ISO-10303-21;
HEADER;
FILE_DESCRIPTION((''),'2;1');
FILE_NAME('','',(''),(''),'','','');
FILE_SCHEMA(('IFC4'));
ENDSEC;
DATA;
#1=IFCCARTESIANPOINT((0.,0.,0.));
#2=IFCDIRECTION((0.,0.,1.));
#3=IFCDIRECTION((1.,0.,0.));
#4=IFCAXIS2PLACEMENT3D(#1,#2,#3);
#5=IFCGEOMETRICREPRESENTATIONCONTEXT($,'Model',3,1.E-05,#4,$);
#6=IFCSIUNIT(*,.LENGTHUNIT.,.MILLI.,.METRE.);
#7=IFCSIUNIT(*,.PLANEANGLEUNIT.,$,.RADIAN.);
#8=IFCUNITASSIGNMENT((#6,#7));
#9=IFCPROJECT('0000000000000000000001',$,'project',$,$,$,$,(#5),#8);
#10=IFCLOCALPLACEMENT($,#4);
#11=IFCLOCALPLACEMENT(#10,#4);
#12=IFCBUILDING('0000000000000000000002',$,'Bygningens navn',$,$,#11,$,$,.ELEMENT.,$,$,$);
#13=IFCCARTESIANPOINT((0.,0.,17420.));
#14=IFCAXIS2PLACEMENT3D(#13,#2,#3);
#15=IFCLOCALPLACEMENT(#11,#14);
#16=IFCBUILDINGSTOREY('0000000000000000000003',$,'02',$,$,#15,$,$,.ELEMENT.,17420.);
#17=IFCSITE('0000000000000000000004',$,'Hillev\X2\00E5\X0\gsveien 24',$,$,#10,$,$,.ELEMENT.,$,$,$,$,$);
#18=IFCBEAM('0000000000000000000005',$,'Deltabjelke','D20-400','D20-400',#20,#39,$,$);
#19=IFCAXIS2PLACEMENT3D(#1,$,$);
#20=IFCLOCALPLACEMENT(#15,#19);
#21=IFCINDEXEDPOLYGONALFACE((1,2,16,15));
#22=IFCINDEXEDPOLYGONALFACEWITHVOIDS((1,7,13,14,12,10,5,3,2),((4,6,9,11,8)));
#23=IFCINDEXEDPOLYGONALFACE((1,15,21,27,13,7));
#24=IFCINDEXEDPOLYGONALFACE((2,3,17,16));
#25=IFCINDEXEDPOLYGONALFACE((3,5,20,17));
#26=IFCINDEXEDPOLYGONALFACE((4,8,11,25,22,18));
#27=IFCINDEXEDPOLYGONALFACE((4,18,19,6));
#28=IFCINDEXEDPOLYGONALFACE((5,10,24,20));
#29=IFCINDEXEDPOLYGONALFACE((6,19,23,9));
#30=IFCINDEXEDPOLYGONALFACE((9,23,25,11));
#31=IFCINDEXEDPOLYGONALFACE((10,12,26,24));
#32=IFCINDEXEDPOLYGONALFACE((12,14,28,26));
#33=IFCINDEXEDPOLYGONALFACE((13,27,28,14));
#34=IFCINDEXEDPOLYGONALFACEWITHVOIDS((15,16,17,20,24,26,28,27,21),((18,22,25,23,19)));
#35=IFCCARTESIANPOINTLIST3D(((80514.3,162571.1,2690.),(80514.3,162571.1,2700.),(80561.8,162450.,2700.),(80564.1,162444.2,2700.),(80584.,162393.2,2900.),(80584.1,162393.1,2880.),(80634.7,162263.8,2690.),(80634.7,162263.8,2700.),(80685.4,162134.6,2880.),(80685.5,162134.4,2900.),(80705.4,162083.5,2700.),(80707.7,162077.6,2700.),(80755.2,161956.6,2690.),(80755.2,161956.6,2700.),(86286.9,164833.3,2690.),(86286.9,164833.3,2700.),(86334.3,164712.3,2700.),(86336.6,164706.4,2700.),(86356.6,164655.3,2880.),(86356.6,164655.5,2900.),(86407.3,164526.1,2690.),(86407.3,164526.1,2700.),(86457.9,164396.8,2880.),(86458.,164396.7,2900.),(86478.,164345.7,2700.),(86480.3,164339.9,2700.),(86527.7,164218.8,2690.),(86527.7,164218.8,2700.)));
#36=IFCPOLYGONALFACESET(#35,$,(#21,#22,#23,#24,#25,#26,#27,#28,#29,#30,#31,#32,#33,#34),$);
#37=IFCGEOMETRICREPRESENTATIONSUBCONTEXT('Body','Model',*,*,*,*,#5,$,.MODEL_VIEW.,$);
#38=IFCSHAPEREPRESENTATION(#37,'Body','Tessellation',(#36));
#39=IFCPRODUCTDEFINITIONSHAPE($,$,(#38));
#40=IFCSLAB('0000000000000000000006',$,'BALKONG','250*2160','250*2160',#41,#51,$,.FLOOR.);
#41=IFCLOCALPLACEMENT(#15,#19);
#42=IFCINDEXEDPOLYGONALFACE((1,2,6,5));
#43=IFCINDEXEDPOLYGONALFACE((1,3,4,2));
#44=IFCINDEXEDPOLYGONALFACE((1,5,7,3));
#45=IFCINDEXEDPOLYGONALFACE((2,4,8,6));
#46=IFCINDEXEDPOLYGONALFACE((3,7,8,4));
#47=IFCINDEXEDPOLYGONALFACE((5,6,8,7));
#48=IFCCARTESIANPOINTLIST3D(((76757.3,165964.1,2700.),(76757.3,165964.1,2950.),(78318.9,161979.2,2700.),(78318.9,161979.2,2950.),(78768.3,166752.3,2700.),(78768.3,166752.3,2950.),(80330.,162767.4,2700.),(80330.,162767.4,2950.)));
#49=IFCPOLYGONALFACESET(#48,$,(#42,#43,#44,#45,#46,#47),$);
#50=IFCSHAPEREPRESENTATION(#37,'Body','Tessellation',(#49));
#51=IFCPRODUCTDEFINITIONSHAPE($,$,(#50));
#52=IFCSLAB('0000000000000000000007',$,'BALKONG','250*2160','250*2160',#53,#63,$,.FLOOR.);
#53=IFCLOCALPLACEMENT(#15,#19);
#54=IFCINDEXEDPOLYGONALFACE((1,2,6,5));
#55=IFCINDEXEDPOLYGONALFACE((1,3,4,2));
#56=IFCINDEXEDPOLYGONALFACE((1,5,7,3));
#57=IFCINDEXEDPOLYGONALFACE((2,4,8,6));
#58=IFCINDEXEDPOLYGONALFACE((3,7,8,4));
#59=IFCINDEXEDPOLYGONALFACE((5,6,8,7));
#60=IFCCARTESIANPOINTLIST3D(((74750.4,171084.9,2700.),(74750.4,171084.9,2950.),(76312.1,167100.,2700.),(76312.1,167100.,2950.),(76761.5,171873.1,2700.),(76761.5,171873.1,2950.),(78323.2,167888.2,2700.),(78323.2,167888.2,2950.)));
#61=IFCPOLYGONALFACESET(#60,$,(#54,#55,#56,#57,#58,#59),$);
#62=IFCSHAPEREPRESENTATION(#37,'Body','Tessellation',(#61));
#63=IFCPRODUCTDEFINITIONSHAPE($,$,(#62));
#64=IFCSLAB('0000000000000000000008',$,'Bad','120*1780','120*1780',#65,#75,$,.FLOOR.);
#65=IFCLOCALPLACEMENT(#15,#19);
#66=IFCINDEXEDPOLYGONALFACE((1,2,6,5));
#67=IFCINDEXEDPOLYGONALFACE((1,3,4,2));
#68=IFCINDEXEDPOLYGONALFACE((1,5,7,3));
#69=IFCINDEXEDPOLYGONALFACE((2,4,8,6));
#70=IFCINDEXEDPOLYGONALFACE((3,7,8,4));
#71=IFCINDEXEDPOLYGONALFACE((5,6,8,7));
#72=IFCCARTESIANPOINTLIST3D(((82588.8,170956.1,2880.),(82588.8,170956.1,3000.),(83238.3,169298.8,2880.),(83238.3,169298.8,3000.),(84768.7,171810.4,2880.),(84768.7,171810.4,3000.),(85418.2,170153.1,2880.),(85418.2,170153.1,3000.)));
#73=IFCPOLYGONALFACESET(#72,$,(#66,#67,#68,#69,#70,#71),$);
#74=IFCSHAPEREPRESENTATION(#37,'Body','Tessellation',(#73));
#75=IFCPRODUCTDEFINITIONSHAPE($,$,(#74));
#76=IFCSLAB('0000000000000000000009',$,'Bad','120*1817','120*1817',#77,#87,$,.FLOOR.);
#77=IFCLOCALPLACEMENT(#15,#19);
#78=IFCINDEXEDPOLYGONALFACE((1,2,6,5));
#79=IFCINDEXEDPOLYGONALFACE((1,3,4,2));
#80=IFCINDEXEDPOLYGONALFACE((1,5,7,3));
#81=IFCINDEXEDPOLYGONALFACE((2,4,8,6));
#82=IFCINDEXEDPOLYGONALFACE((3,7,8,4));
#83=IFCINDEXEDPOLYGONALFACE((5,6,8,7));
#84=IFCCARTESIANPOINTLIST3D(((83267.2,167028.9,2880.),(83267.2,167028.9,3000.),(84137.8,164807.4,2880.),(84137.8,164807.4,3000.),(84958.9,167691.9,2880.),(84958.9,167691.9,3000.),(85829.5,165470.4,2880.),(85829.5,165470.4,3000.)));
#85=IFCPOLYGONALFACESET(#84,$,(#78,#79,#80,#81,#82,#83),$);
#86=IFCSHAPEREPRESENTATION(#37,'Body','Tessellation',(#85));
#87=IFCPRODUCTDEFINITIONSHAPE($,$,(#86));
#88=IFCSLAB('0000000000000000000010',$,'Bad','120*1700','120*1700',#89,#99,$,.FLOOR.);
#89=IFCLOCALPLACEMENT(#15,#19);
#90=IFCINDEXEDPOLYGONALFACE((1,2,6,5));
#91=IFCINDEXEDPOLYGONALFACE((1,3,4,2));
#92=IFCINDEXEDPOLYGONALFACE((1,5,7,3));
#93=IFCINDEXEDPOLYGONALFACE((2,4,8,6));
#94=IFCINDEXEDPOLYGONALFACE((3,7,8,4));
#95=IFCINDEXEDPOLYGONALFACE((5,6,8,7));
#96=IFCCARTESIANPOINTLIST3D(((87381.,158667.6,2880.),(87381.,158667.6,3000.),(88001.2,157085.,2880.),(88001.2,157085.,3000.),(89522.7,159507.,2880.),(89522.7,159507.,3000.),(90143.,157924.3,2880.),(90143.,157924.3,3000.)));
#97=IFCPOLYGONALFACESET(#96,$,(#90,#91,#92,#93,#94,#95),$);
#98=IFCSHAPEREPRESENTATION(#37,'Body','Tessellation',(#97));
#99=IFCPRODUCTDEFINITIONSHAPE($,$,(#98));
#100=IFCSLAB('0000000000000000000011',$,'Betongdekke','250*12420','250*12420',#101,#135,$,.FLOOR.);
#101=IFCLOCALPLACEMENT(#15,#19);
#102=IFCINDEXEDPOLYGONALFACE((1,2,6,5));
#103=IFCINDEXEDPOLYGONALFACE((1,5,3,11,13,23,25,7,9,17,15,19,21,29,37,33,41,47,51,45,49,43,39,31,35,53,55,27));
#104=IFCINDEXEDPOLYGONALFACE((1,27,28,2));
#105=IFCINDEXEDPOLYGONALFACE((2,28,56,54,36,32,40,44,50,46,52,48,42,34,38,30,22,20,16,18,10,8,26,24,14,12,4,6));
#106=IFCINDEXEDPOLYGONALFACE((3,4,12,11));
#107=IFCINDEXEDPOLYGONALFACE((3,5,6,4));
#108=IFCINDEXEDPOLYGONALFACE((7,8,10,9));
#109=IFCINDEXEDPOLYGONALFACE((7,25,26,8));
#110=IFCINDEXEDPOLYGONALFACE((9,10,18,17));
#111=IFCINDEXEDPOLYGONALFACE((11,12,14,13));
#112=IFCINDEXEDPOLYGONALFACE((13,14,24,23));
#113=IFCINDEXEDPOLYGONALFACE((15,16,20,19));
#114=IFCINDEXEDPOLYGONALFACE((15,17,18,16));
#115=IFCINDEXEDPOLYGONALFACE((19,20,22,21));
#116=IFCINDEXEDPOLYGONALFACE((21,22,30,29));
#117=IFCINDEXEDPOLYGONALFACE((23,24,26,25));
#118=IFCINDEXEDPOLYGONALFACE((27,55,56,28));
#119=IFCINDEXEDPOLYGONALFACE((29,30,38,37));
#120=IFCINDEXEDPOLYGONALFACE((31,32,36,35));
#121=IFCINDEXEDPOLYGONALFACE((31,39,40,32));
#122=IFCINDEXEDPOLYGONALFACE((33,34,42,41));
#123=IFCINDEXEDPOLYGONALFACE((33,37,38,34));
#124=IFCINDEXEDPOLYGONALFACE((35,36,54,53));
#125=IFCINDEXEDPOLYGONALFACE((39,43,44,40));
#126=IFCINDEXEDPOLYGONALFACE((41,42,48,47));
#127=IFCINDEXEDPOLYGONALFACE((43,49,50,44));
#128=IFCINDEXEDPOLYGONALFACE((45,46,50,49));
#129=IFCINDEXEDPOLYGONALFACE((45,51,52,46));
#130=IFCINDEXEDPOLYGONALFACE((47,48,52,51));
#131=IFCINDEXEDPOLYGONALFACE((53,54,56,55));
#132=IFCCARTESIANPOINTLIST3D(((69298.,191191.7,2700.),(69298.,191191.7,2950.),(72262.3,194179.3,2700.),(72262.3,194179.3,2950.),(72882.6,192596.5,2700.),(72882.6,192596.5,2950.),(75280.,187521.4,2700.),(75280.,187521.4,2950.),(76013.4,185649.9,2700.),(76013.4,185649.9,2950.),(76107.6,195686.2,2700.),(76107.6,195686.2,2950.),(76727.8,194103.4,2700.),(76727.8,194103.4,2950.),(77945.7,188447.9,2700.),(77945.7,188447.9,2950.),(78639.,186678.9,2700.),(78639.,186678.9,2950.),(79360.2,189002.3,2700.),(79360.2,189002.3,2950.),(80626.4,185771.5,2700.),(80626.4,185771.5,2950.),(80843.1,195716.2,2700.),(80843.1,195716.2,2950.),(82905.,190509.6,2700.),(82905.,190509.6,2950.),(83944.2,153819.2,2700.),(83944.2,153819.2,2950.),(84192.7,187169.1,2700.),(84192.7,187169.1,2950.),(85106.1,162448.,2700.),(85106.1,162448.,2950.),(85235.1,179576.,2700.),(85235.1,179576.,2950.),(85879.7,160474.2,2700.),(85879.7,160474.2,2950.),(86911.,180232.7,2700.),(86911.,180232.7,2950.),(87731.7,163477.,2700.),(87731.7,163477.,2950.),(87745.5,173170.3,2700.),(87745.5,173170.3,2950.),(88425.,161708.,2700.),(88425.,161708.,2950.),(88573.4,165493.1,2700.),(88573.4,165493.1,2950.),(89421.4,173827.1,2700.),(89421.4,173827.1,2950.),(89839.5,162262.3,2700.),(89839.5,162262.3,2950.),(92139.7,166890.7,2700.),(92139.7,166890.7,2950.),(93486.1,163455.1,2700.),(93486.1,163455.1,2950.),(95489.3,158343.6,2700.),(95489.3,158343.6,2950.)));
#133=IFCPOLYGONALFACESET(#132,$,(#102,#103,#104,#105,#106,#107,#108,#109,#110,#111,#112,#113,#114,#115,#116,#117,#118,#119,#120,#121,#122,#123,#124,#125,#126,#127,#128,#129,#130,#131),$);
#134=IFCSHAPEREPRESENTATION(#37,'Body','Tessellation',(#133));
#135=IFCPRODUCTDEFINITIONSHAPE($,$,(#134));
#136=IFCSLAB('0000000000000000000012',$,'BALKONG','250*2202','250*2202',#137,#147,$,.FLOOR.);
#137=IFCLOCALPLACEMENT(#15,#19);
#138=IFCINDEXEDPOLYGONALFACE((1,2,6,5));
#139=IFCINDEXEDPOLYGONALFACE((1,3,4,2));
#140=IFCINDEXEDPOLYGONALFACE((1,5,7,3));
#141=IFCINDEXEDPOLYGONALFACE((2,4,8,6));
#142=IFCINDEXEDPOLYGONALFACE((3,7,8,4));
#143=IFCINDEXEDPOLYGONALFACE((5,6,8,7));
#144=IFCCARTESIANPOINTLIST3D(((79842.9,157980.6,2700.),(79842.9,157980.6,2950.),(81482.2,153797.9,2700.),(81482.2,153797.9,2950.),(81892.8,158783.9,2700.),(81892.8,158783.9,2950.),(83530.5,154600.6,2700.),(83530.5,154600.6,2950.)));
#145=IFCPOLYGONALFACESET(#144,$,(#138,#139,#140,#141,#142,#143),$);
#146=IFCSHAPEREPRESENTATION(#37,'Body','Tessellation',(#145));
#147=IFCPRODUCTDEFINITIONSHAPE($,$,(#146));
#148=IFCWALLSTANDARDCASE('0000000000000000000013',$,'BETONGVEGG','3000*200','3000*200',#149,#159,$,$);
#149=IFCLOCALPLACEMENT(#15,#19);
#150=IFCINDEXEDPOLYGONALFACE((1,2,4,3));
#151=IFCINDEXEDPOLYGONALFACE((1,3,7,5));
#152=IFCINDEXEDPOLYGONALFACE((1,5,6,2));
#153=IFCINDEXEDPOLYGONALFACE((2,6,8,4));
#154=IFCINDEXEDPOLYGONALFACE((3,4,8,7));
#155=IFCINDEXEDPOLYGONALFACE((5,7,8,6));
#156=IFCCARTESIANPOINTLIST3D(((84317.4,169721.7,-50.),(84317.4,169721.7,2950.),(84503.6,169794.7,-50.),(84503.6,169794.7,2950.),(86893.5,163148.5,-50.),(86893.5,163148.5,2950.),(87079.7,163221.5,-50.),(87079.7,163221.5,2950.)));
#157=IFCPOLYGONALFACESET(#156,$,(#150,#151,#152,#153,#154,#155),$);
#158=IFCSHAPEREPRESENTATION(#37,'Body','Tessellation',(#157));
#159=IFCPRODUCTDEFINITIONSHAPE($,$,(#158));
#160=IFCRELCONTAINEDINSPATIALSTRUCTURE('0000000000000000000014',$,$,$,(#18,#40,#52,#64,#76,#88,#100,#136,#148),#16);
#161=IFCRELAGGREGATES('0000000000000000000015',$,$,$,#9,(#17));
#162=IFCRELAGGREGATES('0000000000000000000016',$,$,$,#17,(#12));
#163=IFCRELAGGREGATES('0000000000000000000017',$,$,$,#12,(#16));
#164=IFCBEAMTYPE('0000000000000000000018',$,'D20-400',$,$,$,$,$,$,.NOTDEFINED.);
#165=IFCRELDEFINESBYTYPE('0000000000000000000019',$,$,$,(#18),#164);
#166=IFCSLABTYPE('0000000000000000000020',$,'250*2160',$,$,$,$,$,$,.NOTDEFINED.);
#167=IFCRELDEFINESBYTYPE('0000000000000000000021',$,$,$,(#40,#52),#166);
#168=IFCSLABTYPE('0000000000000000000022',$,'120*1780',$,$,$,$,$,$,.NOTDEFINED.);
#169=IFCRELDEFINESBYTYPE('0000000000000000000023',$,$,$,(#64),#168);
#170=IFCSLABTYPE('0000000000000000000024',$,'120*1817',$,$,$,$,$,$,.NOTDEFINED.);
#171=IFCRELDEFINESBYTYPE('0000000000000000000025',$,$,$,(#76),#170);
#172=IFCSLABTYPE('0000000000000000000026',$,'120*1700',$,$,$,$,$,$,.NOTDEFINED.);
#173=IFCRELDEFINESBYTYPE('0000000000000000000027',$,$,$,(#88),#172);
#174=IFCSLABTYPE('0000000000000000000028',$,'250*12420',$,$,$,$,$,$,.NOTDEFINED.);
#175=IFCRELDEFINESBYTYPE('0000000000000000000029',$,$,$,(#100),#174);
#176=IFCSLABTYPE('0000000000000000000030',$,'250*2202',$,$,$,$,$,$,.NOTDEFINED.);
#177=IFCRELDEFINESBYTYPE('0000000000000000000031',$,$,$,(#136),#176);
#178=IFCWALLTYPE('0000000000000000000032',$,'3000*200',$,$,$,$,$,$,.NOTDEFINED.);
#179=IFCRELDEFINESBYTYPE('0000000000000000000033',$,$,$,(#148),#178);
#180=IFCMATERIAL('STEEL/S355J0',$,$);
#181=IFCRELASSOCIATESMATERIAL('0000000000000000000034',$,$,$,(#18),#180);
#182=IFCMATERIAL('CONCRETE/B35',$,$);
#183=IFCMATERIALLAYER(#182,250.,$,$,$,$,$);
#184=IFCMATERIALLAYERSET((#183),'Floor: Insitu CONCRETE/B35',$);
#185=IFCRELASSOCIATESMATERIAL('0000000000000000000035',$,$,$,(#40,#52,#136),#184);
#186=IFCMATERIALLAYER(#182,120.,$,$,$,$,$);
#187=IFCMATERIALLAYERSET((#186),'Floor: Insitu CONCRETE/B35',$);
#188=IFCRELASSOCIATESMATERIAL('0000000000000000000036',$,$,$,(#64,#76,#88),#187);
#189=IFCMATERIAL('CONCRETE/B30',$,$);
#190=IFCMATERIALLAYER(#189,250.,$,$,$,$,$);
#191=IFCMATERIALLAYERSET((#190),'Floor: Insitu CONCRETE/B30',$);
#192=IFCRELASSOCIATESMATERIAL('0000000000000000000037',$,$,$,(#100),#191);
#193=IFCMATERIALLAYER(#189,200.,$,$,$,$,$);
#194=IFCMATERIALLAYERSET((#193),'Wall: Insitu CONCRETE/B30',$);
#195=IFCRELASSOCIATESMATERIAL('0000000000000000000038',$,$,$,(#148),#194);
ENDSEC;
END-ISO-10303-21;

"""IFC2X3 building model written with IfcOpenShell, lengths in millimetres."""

from ifc_helpers import new_model, si_unit, frame, frame_2d, origin_with_axes, place, context, subcontext, project, spatial, polyline, rectangle, outline, extrude, material, layer, layer_set, layer_usage, type_object, element, save


model = new_model("IFC2X3")

# Units and contexts
model_context = context("Model", 3, precision=1e-05, world=origin_with_axes())
body_context = subcontext(model_context, "Body", "Model", "MODEL_VIEW")
ifc_project = project(units=[si_unit("LENGTHUNIT", "METRE", prefix="MILLI"), si_unit("PLANEANGLEUNIT", "RADIAN")], contexts=[model_context])

# Site, building, storey
site_placement = place(None, origin_with_axes())
site = spatial("IfcSite", under=ifc_project, at=site_placement, Name="Hillevågsveien 24", CompositionType="ELEMENT")
building_placement = place(site_placement, origin_with_axes())
building = spatial("IfcBuilding", under=site, at=building_placement, Name="Bygningens navn", CompositionType="ELEMENT")
storey_placement = place(building_placement, frame((0.0, 0.0, 17420.0), z_axis=(0.0, 0.0, 1.0), x_axis=(1.0, 0.0, 0.0)))
storey = spatial("IfcBuildingStorey", under=building, at=storey_placement, Name="02", CompositionType="ELEMENT", Elevation=17420.0)

# Shared definitions
ifc_material_1 = material(Name="STEEL/S355J0")

# Beam
beam_type_1 = type_object("IfcBeamType", Name="D20-400", PredefinedType="NOTDEFINED")
beam_1_placement = place(storey_placement, frame((86407.3, 164526.1, 2795.0), z_axis=(0.0, 0.0, 1.0), x_axis=(-0.931056, -0.364877, 0.0)))
element("IfcBeam", 1, at=beam_1_placement, inside=storey, type_object=beam_type_1, material=ifc_material_1, Name="Deltabjelke", Description="D20-400", ObjectType="D20-400", context=body_context, shape_type="SweptSolid", body=[
    extrude(outline(polyline([(0.0, -105.0), (-330.0, -105.0), (-330.0, -95.0), (-200.0, -95.0), (-139.0, 105.0), (139.0, 105.0), (200.0, -95.0), (330.0, -95.0), (330.0, -105.0), (0.0, -105.0)]), holes=[polyline([(138.8, 85.0), (-138.8, 85.0), (-193.7, -95.0), (0.0, -95.0), (193.7, -95.0), (138.8, 85.0)])]), frame((6200.0, 0.0, 0.0), z_axis=(-1.0, 0.0, 0.0), x_axis=(0.0, -1.0, 0.0)), (0.0, 0.0, 1.0), 6200.0),
])

# Slabs
ifc_material_2 = material(Name="CONCRETE/B35")
ifc_layer_1 = layer(ifc_material_2, 250.0)
ifc_layer_set_1 = layer_set([ifc_layer_1], Name="Floor: Insitu CONCRETE/B35")
ifc_layer_usage_1 = layer_usage(ifc_layer_set_1, "AXIS3", "POSITIVE", -125.0)
slab_type_1 = type_object("IfcSlabType", Name="250*2160", PredefinedType="NOTDEFINED")
slab_1_placement = place(storey_placement, frame((78318.9, 161979.2, 2825.0), z_axis=(0.0, 0.0, -1.0), x_axis=(-0.364876, 0.931056, 0.0)))
element("IfcSlab", 2, at=slab_1_placement, inside=storey, type_object=slab_type_1, material=ifc_layer_usage_1, Name="BALKONG", Description="250*2160", ObjectType="250*2160", PredefinedType="FLOOR", context=body_context, shape_type="SweptSolid", body=[
    extrude(outline(polyline([(0.0, 0.0), (4280.0, 0.0), (4280.0, 2160.0), (0.0, 2160.0), (0.0, 0.0)])), frame((0.0, 0.0, -125.0), z_axis=(0.0, 0.0, 1.0), x_axis=(1.0, 0.0, 0.0)), (0.0, 0.0, 1.0), 250.0),
])
ifc_layer_usage_2 = layer_usage(ifc_layer_set_1, "AXIS3", "POSITIVE", -125.0)
slab_2_placement = place(storey_placement, frame((76312.1, 167100.0, 2825.0), z_axis=(0.0, 0.0, -1.0), x_axis=(-0.364876, 0.931056, 0.0)))
element("IfcSlab", 3, at=slab_2_placement, inside=storey, type_object=slab_type_1, material=ifc_layer_usage_2, Name="BALKONG", Description="250*2160", ObjectType="250*2160", PredefinedType="FLOOR", context=body_context, shape_type="SweptSolid", body=[
    extrude(outline(polyline([(0.0, 0.0), (4280.0, 0.0), (4280.0, 2160.0), (0.0, 2160.0), (0.0, 0.0)])), frame((0.0, 0.0, -125.0), z_axis=(0.0, 0.0, 1.0), x_axis=(1.0, 0.0, 0.0)), (0.0, 0.0, 1.0), 250.0),
])
ifc_layer_2 = layer(ifc_material_2, 120.0)
ifc_layer_set_2 = layer_set([ifc_layer_2], Name="Floor: Insitu CONCRETE/B35")
ifc_layer_usage_3 = layer_usage(ifc_layer_set_2, "AXIS3", "POSITIVE", -60.0)
slab_type_2 = type_object("IfcSlabType", Name="120*1780", PredefinedType="NOTDEFINED")
slab_3_placement = place(storey_placement, frame((83238.3, 169298.8, 2940.0), z_axis=(0.0, 0.0, -1.0), x_axis=(-0.364877, 0.931056, 0.0)))
element("IfcSlab", 4, at=slab_3_placement, inside=storey, type_object=slab_type_2, material=ifc_layer_usage_3, Name="Bad", Description="120*1780", ObjectType="120*1780", PredefinedType="FLOOR", context=body_context, shape_type="SweptSolid", body=[
    extrude(outline(polyline([(0.0, 0.0), (1780.0, 0.0), (1780.0, 2341.4), (0.0, 2341.4), (0.0, 0.0)])), frame((0.0, 0.0, -60.0), z_axis=(0.0, 0.0, 1.0), x_axis=(1.0, 0.0, 0.0)), (0.0, 0.0, 1.0), 120.0),
])
ifc_layer_usage_4 = layer_usage(ifc_layer_set_2, "AXIS3", "POSITIVE", -60.0)
slab_type_3 = type_object("IfcSlabType", Name="120*1817", PredefinedType="NOTDEFINED")
slab_4_placement = place(storey_placement, frame((84137.8, 164807.4, 2940.0), z_axis=(0.0, 0.0, -1.0), x_axis=(-0.364877, 0.931056, 0.0)))
element("IfcSlab", 5, at=slab_4_placement, inside=storey, type_object=slab_type_3, material=ifc_layer_usage_4, Name="Bad", Description="120*1817", ObjectType="120*1817", PredefinedType="FLOOR", context=body_context, shape_type="SweptSolid", body=[
    extrude(outline(polyline([(0.0, 0.0), (2386.0, 0.0), (2386.0, 1817.0), (0.0, 1817.0), (0.0, 0.0)])), frame((0.0, 0.0, -60.0), z_axis=(0.0, 0.0, 1.0), x_axis=(1.0, 0.0, 0.0)), (0.0, 0.0, 1.0), 120.0),
])
ifc_layer_usage_5 = layer_usage(ifc_layer_set_2, "AXIS3", "POSITIVE", -60.0)
slab_type_4 = type_object("IfcSlabType", Name="120*1700", PredefinedType="NOTDEFINED")
slab_5_placement = place(storey_placement, frame((89522.7, 159507.0, 2940.0), z_axis=(0.0, 0.0, 1.0), x_axis=(-0.931056, -0.364877, 0.0)))
element("IfcSlab", 6, at=slab_5_placement, inside=storey, type_object=slab_type_4, material=ifc_layer_usage_5, Name="Bad", Description="120*1700", ObjectType="120*1700", PredefinedType="FLOOR", context=body_context, shape_type="SweptSolid", body=[
    extrude(outline(polyline([(0.0, 0.0), (2300.4, 0.0), (2300.4, 1699.8), (0.0, 1699.8), (0.0, 0.0)])), frame((0.0, 0.0, -60.0), z_axis=(0.0, 0.0, 1.0), x_axis=(1.0, 0.0, 0.0)), (0.0, 0.0, 1.0), 120.0),
])
ifc_material_3 = material(Name="CONCRETE/B30")
ifc_layer_3 = layer(ifc_material_3, 250.0)
ifc_layer_set_3 = layer_set([ifc_layer_3], Name="Floor: Insitu CONCRETE/B30")
ifc_layer_usage_6 = layer_usage(ifc_layer_set_3, "AXIS3", "POSITIVE", -125.0)
slab_type_5 = type_object("IfcSlabType", Name="250*12420", PredefinedType="NOTDEFINED")
slab_6_placement = place(storey_placement, frame((83944.2, 153819.2, 2825.0), z_axis=(0.0, 0.0, 1.0), x_axis=(0.931056, 0.364877, 0.0)))
element("IfcSlab", 7, at=slab_6_placement, inside=storey, type_object=slab_type_5, material=ifc_layer_usage_6, Name="Betongdekke", Description="250*12420", ObjectType="250*12420", PredefinedType="FLOOR", context=body_context, shape_type="SweptSolid", body=[
    extrude(outline(polyline([(0.0, 0.0), (12400.0, 0.0), (12400.0, 5490.0), (4230.3, 5490.0), (4230.3, 7610.0), (7050.3, 7610.0), (7050.4, 5710.0), (8569.6, 5710.0), (8569.6, 9180.0), (12400.0, 9180.0), (12400.0, 16630.0), (10600.0, 16630.0), (10600.0, 23510.0), (12400.0, 23510.0), (12400.0, 30960.0), (8569.6, 30960.0), (8569.6, 34430.0), (7050.3, 34430.0), (7050.3, 32530.0), (4230.3, 32530.0), (4230.3, 34540.0), (12420.0, 34540.0), (12400.0, 40140.0), (7980.0, 40140.0), (7980.0, 41840.0), (3850.0, 41840.0), (3850.0, 40140.0), (0.0, 40140.0), (0.0, 0.0)])), frame((0.0, 0.0, -125.0), z_axis=(0.0, 0.0, 1.0), x_axis=(1.0, 0.0, 0.0)), (0.0, 0.0, 1.0), 250.0),
])
ifc_layer_usage_7 = layer_usage(ifc_layer_set_1, "AXIS3", "POSITIVE", -125.0)
slab_type_6 = type_object("IfcSlabType", Name="250*2202", PredefinedType="NOTDEFINED")
slab_7_placement = place(storey_placement, frame((79842.9, 157980.6, 2825.0), z_axis=(0.0, 0.0, 1.0), x_axis=(0.364901, -0.931046, 0.0)))
element("IfcSlab", 8, at=slab_7_placement, inside=storey, type_object=slab_type_6, material=ifc_layer_usage_7, Name="BALKONG", Description="250*2202", ObjectType="250*2202", PredefinedType="FLOOR", context=body_context, shape_type="SweptSolid", body=[
    extrude(outline(polyline([(0.0, 0.0), (4492.5, 0.0), (4492.6, 2200.0), (0.1, 2201.7), (0.0, 0.0)])), frame((0.0, 0.0, -125.0), z_axis=(0.0, 0.0, 1.0), x_axis=(1.0, 0.0, 0.0)), (0.0, 0.0, 1.0), 250.0),
])

# Wall
ifc_layer_4 = layer(ifc_material_3, 200.0)
ifc_layer_set_4 = layer_set([ifc_layer_4], Name="Wall: Insitu CONCRETE/B30")
ifc_layer_usage_8 = layer_usage(ifc_layer_set_4, "AXIS2", "POSITIVE", -100.0)
wall_type_1 = type_object("IfcWallType", Name="3000*200", PredefinedType="NOTDEFINED")
wall_1_placement = place(storey_placement, frame((86986.6, 163185.0, -50.0), z_axis=(0.0, 0.0, 1.0), x_axis=(-0.364877, 0.931056, 0.0)))
element("IfcWallStandardCase", 9, at=wall_1_placement, inside=storey, type_object=wall_type_1, material=ifc_layer_usage_8, Name="BETONGVEGG", Description="3000*200", ObjectType="3000*200", context=body_context, shape_type="SweptSolid", body=[
    extrude(rectangle(XDim=7060.0, YDim=200.0, at=frame_2d((0.0, 3530.0), x_axis=(0.0, -1.0))), frame((0.0, 0.0, 0.0), z_axis=(0.0, 0.0, 1.0), x_axis=(0.0, -1.0, 0.0)), (0.0, 0.0, 1.0), 3000.0),
])

save(model, "model.ifc")
